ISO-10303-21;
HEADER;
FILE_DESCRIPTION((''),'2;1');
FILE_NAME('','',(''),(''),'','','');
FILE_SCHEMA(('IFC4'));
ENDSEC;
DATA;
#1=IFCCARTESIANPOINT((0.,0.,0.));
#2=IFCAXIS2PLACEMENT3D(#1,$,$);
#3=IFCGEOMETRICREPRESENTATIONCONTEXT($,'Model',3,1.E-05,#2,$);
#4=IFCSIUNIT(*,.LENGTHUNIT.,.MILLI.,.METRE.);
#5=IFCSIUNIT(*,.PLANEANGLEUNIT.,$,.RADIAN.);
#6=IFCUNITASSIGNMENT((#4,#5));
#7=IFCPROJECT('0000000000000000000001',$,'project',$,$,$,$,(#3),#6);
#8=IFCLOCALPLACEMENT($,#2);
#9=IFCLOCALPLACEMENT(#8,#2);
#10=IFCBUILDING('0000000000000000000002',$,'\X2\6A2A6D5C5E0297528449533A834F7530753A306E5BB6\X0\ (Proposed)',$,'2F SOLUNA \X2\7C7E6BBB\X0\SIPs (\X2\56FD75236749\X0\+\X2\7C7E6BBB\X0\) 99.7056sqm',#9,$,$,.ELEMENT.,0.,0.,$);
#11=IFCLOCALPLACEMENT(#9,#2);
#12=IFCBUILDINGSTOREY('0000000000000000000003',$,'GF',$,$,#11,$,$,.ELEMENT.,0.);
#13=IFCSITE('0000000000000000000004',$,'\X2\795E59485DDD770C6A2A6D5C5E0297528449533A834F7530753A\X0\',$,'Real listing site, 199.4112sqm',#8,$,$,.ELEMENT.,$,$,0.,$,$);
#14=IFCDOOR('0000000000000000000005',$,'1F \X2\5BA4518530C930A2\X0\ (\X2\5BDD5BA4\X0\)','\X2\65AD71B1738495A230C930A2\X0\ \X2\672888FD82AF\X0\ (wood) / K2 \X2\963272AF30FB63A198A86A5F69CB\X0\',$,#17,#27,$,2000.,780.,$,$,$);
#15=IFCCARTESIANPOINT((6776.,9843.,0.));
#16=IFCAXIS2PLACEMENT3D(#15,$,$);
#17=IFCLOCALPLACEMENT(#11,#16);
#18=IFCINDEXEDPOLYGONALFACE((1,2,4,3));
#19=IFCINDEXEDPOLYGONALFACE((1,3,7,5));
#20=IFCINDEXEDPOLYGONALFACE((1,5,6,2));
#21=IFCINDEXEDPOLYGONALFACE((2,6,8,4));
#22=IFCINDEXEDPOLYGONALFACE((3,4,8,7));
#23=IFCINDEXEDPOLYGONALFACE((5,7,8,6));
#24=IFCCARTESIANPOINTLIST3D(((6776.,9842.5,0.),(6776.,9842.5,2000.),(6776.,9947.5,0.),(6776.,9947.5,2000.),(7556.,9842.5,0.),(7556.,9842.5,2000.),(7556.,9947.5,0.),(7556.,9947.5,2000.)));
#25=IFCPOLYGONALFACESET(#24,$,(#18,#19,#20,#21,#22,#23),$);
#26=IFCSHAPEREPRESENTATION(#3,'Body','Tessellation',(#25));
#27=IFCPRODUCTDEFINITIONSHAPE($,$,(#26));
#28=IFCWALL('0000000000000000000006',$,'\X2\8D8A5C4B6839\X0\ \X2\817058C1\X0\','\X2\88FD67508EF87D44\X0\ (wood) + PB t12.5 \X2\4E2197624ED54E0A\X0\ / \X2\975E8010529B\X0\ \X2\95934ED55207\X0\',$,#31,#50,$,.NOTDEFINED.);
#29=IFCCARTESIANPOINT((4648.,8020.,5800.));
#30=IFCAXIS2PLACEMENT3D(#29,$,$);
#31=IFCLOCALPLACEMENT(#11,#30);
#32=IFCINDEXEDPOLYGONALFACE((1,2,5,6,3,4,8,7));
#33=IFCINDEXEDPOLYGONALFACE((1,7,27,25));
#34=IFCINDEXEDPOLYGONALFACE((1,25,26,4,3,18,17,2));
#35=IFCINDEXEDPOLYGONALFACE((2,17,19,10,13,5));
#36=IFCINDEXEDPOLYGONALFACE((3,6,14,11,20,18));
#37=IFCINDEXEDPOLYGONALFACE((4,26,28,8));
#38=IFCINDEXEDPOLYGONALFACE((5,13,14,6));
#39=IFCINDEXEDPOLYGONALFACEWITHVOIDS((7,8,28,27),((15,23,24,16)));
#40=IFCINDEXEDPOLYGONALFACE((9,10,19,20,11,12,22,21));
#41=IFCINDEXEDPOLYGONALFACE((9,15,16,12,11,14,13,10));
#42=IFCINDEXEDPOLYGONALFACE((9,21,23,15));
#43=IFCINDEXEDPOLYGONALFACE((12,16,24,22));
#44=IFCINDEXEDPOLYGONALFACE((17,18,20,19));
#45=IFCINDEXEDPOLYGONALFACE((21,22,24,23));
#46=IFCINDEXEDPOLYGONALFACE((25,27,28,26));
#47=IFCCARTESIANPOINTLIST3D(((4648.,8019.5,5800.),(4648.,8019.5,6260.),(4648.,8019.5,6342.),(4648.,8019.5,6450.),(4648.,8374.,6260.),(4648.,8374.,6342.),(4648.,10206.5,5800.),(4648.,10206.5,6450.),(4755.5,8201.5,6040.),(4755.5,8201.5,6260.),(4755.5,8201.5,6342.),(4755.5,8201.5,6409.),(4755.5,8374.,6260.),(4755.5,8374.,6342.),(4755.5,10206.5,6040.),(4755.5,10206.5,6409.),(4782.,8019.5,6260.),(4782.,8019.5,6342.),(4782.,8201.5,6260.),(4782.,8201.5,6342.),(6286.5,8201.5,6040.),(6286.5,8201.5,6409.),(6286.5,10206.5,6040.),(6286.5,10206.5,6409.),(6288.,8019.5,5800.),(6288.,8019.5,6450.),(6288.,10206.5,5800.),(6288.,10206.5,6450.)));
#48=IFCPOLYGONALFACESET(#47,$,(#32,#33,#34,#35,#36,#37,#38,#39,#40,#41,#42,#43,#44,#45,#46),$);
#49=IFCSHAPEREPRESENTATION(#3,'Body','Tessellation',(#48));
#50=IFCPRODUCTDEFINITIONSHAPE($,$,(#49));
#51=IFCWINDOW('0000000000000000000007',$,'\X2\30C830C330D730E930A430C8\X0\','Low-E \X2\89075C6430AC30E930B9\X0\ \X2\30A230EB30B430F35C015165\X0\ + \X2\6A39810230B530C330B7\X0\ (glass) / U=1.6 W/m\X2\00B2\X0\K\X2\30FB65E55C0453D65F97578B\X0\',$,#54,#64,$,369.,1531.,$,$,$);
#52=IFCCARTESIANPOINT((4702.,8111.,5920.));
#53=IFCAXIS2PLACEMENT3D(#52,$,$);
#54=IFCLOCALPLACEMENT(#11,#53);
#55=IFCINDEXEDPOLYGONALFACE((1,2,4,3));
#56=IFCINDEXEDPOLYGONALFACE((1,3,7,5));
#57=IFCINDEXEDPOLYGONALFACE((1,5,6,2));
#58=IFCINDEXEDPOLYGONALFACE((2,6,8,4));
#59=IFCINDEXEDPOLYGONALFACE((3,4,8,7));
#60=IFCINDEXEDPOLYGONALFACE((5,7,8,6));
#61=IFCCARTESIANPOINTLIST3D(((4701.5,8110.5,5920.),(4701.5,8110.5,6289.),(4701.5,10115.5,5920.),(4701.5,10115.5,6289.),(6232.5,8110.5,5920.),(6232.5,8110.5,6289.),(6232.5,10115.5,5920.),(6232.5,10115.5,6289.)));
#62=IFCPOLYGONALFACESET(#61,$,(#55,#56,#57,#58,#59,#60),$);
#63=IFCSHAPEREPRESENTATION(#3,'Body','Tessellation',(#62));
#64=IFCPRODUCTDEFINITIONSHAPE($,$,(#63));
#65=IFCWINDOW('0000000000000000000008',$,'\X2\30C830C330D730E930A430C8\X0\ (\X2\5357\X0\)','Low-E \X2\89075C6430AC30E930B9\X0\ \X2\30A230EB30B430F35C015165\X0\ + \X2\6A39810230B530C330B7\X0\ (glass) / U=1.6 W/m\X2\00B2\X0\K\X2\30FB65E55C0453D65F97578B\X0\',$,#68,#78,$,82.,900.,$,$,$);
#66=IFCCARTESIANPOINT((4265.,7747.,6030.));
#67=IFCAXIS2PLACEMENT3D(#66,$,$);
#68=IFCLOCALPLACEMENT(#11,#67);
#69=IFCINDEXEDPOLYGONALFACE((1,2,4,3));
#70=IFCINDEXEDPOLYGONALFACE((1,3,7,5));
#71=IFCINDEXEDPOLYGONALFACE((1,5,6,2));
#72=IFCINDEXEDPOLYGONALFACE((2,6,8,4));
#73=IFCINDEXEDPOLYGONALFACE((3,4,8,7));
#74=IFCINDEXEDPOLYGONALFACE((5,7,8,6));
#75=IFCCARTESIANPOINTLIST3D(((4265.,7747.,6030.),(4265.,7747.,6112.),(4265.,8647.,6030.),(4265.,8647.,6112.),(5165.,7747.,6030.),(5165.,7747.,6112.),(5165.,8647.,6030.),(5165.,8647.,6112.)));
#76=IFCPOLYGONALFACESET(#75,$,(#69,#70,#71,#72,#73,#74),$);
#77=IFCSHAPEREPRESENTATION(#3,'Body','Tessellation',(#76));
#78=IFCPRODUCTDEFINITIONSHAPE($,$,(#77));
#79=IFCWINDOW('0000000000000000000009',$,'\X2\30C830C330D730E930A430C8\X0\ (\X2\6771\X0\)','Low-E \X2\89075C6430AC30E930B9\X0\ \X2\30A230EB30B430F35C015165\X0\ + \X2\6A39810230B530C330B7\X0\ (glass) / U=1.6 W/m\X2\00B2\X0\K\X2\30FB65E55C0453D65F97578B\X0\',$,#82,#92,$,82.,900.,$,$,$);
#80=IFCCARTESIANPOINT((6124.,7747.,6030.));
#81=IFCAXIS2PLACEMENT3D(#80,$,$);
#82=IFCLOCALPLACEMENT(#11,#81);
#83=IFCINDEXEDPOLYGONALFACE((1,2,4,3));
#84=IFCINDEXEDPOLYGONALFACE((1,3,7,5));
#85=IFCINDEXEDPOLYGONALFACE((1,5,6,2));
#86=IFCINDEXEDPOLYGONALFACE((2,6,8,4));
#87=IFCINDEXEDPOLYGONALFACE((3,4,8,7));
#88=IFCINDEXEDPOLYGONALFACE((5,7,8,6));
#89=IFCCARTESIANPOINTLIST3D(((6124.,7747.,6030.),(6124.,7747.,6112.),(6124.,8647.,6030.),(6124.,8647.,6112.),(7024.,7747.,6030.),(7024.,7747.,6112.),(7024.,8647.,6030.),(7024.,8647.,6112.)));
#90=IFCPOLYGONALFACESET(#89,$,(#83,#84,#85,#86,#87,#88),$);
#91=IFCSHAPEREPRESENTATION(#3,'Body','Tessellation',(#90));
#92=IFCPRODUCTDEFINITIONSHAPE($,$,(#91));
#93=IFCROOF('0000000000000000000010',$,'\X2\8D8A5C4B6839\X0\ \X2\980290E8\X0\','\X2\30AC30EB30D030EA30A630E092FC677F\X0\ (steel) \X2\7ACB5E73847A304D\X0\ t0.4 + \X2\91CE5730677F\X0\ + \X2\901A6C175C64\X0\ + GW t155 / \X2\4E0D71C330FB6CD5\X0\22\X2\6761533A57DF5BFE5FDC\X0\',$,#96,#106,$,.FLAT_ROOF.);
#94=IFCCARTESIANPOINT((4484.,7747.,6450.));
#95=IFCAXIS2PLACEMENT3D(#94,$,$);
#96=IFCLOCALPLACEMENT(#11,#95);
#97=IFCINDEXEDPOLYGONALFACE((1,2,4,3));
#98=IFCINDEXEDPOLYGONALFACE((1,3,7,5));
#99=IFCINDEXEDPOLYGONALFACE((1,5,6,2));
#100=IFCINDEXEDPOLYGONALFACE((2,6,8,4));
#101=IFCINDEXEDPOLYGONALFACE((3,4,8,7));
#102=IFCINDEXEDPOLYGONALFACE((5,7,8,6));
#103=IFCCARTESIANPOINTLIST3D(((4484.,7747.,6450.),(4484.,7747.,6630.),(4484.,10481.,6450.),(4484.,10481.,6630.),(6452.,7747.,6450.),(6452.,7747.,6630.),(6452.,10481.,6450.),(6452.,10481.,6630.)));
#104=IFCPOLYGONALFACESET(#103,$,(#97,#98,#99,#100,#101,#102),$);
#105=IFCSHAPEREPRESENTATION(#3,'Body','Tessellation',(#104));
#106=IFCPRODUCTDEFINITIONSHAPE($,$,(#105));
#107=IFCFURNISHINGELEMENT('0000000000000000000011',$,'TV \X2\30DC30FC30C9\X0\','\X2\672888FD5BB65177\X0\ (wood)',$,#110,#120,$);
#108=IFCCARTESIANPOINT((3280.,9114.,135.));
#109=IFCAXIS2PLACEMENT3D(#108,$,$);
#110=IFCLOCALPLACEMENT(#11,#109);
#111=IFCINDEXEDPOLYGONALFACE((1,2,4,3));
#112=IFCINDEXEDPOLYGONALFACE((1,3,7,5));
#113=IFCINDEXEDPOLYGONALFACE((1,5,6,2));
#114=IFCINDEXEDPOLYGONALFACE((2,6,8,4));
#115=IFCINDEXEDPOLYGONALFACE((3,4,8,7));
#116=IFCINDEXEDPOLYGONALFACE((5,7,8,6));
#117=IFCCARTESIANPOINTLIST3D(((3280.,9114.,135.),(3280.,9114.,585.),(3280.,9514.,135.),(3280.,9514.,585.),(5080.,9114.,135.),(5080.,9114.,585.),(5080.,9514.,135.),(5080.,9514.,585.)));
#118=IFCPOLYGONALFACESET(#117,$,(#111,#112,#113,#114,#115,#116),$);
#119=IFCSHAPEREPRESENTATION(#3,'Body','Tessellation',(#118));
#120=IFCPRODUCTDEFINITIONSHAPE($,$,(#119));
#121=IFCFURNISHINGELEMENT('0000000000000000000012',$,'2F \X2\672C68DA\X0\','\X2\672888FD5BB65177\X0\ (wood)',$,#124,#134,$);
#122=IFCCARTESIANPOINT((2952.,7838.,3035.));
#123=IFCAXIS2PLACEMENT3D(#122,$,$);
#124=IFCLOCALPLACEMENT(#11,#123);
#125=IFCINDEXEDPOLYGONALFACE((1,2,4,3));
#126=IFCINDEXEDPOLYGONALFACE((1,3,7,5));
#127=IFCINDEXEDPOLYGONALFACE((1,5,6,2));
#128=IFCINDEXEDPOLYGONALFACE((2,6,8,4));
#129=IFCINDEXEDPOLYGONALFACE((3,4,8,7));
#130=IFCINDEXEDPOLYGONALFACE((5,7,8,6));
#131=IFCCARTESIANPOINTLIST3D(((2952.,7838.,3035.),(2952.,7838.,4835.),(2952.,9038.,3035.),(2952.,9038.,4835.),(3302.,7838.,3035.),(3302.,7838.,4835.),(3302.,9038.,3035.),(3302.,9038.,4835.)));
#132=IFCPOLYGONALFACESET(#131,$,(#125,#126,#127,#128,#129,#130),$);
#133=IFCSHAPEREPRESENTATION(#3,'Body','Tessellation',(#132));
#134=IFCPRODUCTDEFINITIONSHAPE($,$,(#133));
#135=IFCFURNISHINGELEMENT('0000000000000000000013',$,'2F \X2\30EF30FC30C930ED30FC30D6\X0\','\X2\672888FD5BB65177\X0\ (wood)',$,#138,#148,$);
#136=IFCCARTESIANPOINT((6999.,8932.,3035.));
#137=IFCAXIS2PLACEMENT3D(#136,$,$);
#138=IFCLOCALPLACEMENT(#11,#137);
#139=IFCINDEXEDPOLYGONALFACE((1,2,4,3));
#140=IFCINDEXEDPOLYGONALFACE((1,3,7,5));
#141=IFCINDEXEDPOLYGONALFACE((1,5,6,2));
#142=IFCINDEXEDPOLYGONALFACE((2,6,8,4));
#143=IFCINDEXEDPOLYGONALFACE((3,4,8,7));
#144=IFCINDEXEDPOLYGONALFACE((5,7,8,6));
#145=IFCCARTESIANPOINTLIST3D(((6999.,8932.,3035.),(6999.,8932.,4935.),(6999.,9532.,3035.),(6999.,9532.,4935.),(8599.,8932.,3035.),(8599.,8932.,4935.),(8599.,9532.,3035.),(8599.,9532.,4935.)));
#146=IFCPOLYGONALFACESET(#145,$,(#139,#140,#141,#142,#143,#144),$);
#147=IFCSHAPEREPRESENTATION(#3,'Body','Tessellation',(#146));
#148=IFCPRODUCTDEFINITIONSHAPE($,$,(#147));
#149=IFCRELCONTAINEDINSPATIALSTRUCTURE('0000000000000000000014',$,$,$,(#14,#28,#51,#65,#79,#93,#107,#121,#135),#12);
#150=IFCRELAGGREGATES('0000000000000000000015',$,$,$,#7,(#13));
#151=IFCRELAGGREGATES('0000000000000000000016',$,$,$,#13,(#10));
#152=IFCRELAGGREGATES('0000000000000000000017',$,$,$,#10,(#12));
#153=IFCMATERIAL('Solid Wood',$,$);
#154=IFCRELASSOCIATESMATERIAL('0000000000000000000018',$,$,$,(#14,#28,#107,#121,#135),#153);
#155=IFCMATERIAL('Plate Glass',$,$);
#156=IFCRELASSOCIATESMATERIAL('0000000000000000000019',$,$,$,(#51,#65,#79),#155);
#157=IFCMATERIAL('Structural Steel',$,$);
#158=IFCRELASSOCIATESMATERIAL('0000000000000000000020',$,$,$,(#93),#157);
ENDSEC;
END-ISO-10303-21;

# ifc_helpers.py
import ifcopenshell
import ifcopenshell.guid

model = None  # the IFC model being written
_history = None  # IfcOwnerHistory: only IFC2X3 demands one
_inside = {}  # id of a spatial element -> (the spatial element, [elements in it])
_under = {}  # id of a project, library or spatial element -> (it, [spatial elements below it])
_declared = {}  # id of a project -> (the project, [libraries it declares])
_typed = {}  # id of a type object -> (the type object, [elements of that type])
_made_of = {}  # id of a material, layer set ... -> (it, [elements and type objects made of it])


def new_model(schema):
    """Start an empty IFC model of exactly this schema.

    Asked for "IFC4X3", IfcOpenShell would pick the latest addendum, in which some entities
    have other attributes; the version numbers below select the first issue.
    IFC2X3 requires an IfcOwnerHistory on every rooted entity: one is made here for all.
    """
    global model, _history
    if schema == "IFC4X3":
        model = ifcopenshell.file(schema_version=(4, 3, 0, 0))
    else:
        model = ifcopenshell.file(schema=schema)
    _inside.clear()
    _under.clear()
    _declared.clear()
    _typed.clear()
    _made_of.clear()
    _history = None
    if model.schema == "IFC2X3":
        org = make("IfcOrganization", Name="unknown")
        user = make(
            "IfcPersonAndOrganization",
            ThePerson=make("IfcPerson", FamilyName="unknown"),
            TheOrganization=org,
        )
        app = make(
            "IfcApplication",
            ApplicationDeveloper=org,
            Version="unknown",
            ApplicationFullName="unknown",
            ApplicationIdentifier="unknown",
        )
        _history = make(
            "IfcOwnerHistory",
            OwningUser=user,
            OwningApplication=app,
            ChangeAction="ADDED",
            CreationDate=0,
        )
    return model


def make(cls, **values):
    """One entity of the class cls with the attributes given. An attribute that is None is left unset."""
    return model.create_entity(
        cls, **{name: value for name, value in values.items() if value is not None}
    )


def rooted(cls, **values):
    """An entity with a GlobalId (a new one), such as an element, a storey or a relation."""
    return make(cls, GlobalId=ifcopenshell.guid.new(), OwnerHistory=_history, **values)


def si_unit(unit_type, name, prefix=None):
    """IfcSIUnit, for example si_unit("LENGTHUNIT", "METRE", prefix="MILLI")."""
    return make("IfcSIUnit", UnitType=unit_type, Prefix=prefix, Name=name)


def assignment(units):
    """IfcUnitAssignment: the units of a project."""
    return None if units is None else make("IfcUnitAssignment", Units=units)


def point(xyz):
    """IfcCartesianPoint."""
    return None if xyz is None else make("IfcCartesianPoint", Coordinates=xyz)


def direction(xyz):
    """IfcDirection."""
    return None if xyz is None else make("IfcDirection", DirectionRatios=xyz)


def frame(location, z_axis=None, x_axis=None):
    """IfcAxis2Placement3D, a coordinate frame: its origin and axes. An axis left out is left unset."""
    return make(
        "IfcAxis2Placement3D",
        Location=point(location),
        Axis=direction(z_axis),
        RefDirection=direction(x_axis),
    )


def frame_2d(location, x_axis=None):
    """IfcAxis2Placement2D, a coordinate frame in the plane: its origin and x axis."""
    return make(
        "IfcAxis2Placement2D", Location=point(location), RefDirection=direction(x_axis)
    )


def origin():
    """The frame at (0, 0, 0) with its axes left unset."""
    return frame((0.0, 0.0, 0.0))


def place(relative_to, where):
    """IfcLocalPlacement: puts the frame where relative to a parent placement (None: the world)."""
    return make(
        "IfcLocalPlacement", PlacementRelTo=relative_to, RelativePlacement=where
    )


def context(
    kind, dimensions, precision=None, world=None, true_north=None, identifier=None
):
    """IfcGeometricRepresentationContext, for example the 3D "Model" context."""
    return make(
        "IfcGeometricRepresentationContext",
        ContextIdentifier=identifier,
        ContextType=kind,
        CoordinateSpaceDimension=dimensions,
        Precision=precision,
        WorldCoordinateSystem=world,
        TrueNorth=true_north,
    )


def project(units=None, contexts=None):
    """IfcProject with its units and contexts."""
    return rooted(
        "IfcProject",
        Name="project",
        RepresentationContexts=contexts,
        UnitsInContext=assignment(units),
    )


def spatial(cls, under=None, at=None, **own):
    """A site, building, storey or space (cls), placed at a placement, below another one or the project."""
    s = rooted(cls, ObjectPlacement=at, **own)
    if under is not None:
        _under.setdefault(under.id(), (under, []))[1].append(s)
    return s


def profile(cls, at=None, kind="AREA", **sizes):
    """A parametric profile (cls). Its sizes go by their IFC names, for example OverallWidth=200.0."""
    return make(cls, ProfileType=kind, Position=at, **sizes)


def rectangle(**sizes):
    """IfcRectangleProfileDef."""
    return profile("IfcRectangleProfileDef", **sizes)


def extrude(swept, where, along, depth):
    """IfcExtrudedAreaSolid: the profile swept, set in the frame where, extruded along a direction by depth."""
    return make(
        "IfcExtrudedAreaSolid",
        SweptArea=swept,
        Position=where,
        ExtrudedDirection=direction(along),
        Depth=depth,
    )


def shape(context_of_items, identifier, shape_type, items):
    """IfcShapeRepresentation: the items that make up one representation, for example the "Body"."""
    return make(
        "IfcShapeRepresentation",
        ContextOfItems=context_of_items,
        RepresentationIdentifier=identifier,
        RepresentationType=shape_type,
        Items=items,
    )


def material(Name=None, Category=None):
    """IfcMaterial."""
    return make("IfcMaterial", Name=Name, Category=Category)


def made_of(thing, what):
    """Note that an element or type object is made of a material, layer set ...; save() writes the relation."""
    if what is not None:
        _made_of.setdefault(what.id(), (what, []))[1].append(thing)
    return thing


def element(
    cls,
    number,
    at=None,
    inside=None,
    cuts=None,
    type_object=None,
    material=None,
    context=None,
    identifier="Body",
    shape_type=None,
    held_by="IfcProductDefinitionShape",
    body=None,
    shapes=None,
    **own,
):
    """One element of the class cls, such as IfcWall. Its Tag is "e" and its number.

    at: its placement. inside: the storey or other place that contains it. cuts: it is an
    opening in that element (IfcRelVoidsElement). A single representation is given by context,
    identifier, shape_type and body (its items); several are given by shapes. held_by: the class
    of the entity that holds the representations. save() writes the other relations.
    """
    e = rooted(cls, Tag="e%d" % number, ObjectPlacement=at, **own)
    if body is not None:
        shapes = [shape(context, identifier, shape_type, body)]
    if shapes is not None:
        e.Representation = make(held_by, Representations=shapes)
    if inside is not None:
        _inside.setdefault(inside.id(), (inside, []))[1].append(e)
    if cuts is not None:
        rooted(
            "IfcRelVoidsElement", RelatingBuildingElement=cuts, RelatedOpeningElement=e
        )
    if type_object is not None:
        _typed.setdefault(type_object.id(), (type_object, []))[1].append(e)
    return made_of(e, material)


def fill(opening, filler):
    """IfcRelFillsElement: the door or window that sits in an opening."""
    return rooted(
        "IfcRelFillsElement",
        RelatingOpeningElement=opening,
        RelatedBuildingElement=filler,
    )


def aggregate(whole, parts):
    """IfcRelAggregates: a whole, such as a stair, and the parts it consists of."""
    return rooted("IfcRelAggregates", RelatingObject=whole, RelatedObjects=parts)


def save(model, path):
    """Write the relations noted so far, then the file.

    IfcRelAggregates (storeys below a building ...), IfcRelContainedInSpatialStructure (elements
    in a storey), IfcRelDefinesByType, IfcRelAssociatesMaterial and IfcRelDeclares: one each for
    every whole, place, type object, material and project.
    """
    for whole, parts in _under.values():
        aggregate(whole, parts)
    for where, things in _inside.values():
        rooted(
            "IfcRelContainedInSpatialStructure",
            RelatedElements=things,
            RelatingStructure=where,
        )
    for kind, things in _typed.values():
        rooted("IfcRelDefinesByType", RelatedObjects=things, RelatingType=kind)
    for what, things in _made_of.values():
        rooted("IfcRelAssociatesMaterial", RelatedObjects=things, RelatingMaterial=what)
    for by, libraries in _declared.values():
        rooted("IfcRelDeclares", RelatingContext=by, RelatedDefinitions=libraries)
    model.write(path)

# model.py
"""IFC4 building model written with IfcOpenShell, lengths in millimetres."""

from ifc_helpers import new_model, si_unit, frame, frame_2d, origin, place, context, project, spatial, rectangle, extrude, material, element, fill, save


model = new_model("IFC4")

# Units and contexts
model_context = context("Model", 3, precision=1e-05, world=origin())
ifc_project = project(units=[si_unit("LENGTHUNIT", "METRE", prefix="MILLI"), si_unit("PLANEANGLEUNIT", "RADIAN")], contexts=[model_context])

# Site, building, storey
site_placement = place(None, origin())
site = spatial("IfcSite", under=ifc_project, at=site_placement, Name="神奈川県横浜市青葉区荏田町", ObjectType="Real listing site, 199.4112sqm", CompositionType="ELEMENT", RefElevation=0.0)
building_placement = place(site_placement, origin())
building = spatial("IfcBuilding", under=site, at=building_placement, Name="横浜市青葉区荏田町の家 (Proposed)", ObjectType="2F SOLUNA 籾殻SIPs (国産杉+籾殻) 99.7056sqm", CompositionType="ELEMENT", ElevationOfRefHeight=0.0, ElevationOfTerrain=0.0)
storey_placement = place(building_placement, origin())
storey = spatial("IfcBuildingStorey", under=building, at=storey_placement, Name="GF", CompositionType="ELEMENT", Elevation=0.0)

# Shared definitions
ifc_material_1 = material(Name="Solid Wood")

# Door
door_placement = place(storey_placement, frame((6776.0, 9843.0, 0.0)))
element("IfcDoor", 1, at=door_placement, inside=storey, material=ifc_material_1, Name="1F 室内ドア (寝室)", Description="断熱玄関ドア 木製芯 (wood) / K2 防犯・採風機構", OverallHeight=2000.0, OverallWidth=780.0, context=model_context, shape_type="SweptSolid", body=[
    extrude(rectangle(XDim=780.0, YDim=105.0, at=frame_2d((390.0, 52.0))), frame((6776.0, 9843.0, 0.0)), (0.0, 0.0, 1.0), 2000.0),
])

# Wall, openings, windows
wall_1_placement = place(storey_placement, frame((4648.0, 8020.0, 5800.0)))
wall_1 = element("IfcWall", 2, at=wall_1_placement, inside=storey, material=ifc_material_1, Name="越屋根 腰壁", Description="製材軸組 (wood) + PB t12.5 両面仕上 / 非耐力 間仕切", PredefinedType="NOTDEFINED", context=model_context, shape_type="SweptSolid", body=[
    extrude(rectangle(XDim=1640.0, YDim=2187.0, at=frame_2d((820.0, 1093.0))), frame((4648.0, 8020.0, 5800.0)), (0.0, 0.0, 1.0), 650.0),
])
opening_1_placement = place(storey_placement, frame((4702.0, 8111.0, 5920.0)))
opening_1 = element("IfcOpeningElement", 3, at=opening_1_placement, cuts=wall_1, PredefinedType="NOTDEFINED", context=model_context, shape_type="SweptSolid", body=[
    extrude(rectangle(XDim=1531.0, YDim=2005.0, at=frame_2d((765.0, 1002.0))), frame((4702.0, 8111.0, 5920.0)), (0.0, 0.0, 1.0), 369.0),
])
opening_2_placement = place(storey_placement, frame((4265.0, 7747.0, 6030.0)))
opening_2 = element("IfcOpeningElement", 4, at=opening_2_placement, cuts=wall_1, PredefinedType="NOTDEFINED", context=model_context, shape_type="SweptSolid", body=[
    extrude(rectangle(XDim=900.0, YDim=900.0, at=frame_2d((450.0, 450.0))), frame((4265.0, 7747.0, 6030.0)), (0.0, 0.0, 1.0), 82.0),
])
opening_3_placement = place(storey_placement, frame((6124.0, 7747.0, 6030.0)))
opening_3 = element("IfcOpeningElement", 5, at=opening_3_placement, cuts=wall_1, PredefinedType="NOTDEFINED", context=model_context, shape_type="SweptSolid", body=[
    extrude(rectangle(XDim=900.0, YDim=900.0, at=frame_2d((450.0, 450.0))), frame((6124.0, 7747.0, 6030.0)), (0.0, 0.0, 1.0), 82.0),
])
ifc_material_2 = material(Name="Plate Glass")
window_1_placement = place(storey_placement, frame((4702.0, 8111.0, 5920.0)))
window_1 = element("IfcWindow", 6, at=window_1_placement, inside=storey, material=ifc_material_2, Name="トップライト", Description="Low-E 複層ガラス アルゴン封入 + 樹脂サッシ (glass) / U=1.6 W/m²K・日射取得型", OverallHeight=369.0, OverallWidth=1531.0, context=model_context, shape_type="SweptSolid", body=[
    extrude(rectangle(XDim=1531.0, YDim=2005.0, at=frame_2d((765.0, 1002.0))), frame((4702.0, 8111.0, 5920.0)), (0.0, 0.0, 1.0), 369.0),
])
fill(opening_1, window_1)
window_2_placement = place(storey_placement, frame((4265.0, 7747.0, 6030.0)))
window_2 = element("IfcWindow", 7, at=window_2_placement, inside=storey, material=ifc_material_2, Name="トップライト (南)", Description="Low-E 複層ガラス アルゴン封入 + 樹脂サッシ (glass) / U=1.6 W/m²K・日射取得型", OverallHeight=82.0, OverallWidth=900.0, context=model_context, shape_type="SweptSolid", body=[
    extrude(rectangle(XDim=900.0, YDim=900.0, at=frame_2d((450.0, 450.0))), frame((4265.0, 7747.0, 6030.0)), (0.0, 0.0, 1.0), 82.0),
])
fill(opening_2, window_2)
window_3_placement = place(storey_placement, frame((6124.0, 7747.0, 6030.0)))
window_3 = element("IfcWindow", 8, at=window_3_placement, inside=storey, material=ifc_material_2, Name="トップライト (東)", Description="Low-E 複層ガラス アルゴン封入 + 樹脂サッシ (glass) / U=1.6 W/m²K・日射取得型", OverallHeight=82.0, OverallWidth=900.0, context=model_context, shape_type="SweptSolid", body=[
    extrude(rectangle(XDim=900.0, YDim=900.0, at=frame_2d((450.0, 450.0))), frame((6124.0, 7747.0, 6030.0)), (0.0, 0.0, 1.0), 82.0),
])
fill(opening_3, window_3)

# Roof
ifc_material_3 = material(Name="Structural Steel")
roof_placement = place(storey_placement, frame((4484.0, 7747.0, 6450.0)))
element("IfcRoof", 9, at=roof_placement, inside=storey, material=ifc_material_3, Name="越屋根 頂部", Description="ガルバリウム鋼板 (steel) 立平葺き t0.4 + 野地板 + 通気層 + GW t155 / 不燃・法22条区域対応", PredefinedType="FLAT_ROOF", context=model_context, shape_type="SweptSolid", body=[
    extrude(rectangle(XDim=1968.0, YDim=2734.0, at=frame_2d((984.0, 1367.0))), frame((4484.0, 7747.0, 6450.0)), (0.0, 0.0, 1.0), 180.0),
])

# Furnishing elements
furnishing_1_placement = place(storey_placement, frame((3280.0, 9114.0, 135.0)))
element("IfcFurnishingElement", 10, at=furnishing_1_placement, inside=storey, material=ifc_material_1, Name="TV ボード", Description="木製家具 (wood)", context=model_context, shape_type="SweptSolid", body=[
    extrude(rectangle(XDim=1800.0, YDim=400.0, at=frame_2d((900.0, 200.0))), frame((3280.0, 9114.0, 135.0)), (0.0, 0.0, 1.0), 450.0),
])
furnishing_2_placement = place(storey_placement, frame((2952.0, 7838.0, 3035.0)))
element("IfcFurnishingElement", 11, at=furnishing_2_placement, inside=storey, material=ifc_material_1, Name="2F 本棚", Description="木製家具 (wood)", context=model_context, shape_type="SweptSolid", body=[
    extrude(rectangle(XDim=350.0, YDim=1200.0, at=frame_2d((175.0, 600.0))), frame((2952.0, 7838.0, 3035.0)), (0.0, 0.0, 1.0), 1800.0),
])
furnishing_3_placement = place(storey_placement, frame((6999.0, 8932.0, 3035.0)))
element("IfcFurnishingElement", 12, at=furnishing_3_placement, inside=storey, material=ifc_material_1, Name="2F ワードローブ", Description="木製家具 (wood)", context=model_context, shape_type="SweptSolid", body=[
    extrude(rectangle(XDim=1600.0, YDim=600.0, at=frame_2d((800.0, 300.0))), frame((6999.0, 8932.0, 3035.0)), (0.0, 0.0, 1.0), 1900.0),
])

save(model, "model.ifc")
